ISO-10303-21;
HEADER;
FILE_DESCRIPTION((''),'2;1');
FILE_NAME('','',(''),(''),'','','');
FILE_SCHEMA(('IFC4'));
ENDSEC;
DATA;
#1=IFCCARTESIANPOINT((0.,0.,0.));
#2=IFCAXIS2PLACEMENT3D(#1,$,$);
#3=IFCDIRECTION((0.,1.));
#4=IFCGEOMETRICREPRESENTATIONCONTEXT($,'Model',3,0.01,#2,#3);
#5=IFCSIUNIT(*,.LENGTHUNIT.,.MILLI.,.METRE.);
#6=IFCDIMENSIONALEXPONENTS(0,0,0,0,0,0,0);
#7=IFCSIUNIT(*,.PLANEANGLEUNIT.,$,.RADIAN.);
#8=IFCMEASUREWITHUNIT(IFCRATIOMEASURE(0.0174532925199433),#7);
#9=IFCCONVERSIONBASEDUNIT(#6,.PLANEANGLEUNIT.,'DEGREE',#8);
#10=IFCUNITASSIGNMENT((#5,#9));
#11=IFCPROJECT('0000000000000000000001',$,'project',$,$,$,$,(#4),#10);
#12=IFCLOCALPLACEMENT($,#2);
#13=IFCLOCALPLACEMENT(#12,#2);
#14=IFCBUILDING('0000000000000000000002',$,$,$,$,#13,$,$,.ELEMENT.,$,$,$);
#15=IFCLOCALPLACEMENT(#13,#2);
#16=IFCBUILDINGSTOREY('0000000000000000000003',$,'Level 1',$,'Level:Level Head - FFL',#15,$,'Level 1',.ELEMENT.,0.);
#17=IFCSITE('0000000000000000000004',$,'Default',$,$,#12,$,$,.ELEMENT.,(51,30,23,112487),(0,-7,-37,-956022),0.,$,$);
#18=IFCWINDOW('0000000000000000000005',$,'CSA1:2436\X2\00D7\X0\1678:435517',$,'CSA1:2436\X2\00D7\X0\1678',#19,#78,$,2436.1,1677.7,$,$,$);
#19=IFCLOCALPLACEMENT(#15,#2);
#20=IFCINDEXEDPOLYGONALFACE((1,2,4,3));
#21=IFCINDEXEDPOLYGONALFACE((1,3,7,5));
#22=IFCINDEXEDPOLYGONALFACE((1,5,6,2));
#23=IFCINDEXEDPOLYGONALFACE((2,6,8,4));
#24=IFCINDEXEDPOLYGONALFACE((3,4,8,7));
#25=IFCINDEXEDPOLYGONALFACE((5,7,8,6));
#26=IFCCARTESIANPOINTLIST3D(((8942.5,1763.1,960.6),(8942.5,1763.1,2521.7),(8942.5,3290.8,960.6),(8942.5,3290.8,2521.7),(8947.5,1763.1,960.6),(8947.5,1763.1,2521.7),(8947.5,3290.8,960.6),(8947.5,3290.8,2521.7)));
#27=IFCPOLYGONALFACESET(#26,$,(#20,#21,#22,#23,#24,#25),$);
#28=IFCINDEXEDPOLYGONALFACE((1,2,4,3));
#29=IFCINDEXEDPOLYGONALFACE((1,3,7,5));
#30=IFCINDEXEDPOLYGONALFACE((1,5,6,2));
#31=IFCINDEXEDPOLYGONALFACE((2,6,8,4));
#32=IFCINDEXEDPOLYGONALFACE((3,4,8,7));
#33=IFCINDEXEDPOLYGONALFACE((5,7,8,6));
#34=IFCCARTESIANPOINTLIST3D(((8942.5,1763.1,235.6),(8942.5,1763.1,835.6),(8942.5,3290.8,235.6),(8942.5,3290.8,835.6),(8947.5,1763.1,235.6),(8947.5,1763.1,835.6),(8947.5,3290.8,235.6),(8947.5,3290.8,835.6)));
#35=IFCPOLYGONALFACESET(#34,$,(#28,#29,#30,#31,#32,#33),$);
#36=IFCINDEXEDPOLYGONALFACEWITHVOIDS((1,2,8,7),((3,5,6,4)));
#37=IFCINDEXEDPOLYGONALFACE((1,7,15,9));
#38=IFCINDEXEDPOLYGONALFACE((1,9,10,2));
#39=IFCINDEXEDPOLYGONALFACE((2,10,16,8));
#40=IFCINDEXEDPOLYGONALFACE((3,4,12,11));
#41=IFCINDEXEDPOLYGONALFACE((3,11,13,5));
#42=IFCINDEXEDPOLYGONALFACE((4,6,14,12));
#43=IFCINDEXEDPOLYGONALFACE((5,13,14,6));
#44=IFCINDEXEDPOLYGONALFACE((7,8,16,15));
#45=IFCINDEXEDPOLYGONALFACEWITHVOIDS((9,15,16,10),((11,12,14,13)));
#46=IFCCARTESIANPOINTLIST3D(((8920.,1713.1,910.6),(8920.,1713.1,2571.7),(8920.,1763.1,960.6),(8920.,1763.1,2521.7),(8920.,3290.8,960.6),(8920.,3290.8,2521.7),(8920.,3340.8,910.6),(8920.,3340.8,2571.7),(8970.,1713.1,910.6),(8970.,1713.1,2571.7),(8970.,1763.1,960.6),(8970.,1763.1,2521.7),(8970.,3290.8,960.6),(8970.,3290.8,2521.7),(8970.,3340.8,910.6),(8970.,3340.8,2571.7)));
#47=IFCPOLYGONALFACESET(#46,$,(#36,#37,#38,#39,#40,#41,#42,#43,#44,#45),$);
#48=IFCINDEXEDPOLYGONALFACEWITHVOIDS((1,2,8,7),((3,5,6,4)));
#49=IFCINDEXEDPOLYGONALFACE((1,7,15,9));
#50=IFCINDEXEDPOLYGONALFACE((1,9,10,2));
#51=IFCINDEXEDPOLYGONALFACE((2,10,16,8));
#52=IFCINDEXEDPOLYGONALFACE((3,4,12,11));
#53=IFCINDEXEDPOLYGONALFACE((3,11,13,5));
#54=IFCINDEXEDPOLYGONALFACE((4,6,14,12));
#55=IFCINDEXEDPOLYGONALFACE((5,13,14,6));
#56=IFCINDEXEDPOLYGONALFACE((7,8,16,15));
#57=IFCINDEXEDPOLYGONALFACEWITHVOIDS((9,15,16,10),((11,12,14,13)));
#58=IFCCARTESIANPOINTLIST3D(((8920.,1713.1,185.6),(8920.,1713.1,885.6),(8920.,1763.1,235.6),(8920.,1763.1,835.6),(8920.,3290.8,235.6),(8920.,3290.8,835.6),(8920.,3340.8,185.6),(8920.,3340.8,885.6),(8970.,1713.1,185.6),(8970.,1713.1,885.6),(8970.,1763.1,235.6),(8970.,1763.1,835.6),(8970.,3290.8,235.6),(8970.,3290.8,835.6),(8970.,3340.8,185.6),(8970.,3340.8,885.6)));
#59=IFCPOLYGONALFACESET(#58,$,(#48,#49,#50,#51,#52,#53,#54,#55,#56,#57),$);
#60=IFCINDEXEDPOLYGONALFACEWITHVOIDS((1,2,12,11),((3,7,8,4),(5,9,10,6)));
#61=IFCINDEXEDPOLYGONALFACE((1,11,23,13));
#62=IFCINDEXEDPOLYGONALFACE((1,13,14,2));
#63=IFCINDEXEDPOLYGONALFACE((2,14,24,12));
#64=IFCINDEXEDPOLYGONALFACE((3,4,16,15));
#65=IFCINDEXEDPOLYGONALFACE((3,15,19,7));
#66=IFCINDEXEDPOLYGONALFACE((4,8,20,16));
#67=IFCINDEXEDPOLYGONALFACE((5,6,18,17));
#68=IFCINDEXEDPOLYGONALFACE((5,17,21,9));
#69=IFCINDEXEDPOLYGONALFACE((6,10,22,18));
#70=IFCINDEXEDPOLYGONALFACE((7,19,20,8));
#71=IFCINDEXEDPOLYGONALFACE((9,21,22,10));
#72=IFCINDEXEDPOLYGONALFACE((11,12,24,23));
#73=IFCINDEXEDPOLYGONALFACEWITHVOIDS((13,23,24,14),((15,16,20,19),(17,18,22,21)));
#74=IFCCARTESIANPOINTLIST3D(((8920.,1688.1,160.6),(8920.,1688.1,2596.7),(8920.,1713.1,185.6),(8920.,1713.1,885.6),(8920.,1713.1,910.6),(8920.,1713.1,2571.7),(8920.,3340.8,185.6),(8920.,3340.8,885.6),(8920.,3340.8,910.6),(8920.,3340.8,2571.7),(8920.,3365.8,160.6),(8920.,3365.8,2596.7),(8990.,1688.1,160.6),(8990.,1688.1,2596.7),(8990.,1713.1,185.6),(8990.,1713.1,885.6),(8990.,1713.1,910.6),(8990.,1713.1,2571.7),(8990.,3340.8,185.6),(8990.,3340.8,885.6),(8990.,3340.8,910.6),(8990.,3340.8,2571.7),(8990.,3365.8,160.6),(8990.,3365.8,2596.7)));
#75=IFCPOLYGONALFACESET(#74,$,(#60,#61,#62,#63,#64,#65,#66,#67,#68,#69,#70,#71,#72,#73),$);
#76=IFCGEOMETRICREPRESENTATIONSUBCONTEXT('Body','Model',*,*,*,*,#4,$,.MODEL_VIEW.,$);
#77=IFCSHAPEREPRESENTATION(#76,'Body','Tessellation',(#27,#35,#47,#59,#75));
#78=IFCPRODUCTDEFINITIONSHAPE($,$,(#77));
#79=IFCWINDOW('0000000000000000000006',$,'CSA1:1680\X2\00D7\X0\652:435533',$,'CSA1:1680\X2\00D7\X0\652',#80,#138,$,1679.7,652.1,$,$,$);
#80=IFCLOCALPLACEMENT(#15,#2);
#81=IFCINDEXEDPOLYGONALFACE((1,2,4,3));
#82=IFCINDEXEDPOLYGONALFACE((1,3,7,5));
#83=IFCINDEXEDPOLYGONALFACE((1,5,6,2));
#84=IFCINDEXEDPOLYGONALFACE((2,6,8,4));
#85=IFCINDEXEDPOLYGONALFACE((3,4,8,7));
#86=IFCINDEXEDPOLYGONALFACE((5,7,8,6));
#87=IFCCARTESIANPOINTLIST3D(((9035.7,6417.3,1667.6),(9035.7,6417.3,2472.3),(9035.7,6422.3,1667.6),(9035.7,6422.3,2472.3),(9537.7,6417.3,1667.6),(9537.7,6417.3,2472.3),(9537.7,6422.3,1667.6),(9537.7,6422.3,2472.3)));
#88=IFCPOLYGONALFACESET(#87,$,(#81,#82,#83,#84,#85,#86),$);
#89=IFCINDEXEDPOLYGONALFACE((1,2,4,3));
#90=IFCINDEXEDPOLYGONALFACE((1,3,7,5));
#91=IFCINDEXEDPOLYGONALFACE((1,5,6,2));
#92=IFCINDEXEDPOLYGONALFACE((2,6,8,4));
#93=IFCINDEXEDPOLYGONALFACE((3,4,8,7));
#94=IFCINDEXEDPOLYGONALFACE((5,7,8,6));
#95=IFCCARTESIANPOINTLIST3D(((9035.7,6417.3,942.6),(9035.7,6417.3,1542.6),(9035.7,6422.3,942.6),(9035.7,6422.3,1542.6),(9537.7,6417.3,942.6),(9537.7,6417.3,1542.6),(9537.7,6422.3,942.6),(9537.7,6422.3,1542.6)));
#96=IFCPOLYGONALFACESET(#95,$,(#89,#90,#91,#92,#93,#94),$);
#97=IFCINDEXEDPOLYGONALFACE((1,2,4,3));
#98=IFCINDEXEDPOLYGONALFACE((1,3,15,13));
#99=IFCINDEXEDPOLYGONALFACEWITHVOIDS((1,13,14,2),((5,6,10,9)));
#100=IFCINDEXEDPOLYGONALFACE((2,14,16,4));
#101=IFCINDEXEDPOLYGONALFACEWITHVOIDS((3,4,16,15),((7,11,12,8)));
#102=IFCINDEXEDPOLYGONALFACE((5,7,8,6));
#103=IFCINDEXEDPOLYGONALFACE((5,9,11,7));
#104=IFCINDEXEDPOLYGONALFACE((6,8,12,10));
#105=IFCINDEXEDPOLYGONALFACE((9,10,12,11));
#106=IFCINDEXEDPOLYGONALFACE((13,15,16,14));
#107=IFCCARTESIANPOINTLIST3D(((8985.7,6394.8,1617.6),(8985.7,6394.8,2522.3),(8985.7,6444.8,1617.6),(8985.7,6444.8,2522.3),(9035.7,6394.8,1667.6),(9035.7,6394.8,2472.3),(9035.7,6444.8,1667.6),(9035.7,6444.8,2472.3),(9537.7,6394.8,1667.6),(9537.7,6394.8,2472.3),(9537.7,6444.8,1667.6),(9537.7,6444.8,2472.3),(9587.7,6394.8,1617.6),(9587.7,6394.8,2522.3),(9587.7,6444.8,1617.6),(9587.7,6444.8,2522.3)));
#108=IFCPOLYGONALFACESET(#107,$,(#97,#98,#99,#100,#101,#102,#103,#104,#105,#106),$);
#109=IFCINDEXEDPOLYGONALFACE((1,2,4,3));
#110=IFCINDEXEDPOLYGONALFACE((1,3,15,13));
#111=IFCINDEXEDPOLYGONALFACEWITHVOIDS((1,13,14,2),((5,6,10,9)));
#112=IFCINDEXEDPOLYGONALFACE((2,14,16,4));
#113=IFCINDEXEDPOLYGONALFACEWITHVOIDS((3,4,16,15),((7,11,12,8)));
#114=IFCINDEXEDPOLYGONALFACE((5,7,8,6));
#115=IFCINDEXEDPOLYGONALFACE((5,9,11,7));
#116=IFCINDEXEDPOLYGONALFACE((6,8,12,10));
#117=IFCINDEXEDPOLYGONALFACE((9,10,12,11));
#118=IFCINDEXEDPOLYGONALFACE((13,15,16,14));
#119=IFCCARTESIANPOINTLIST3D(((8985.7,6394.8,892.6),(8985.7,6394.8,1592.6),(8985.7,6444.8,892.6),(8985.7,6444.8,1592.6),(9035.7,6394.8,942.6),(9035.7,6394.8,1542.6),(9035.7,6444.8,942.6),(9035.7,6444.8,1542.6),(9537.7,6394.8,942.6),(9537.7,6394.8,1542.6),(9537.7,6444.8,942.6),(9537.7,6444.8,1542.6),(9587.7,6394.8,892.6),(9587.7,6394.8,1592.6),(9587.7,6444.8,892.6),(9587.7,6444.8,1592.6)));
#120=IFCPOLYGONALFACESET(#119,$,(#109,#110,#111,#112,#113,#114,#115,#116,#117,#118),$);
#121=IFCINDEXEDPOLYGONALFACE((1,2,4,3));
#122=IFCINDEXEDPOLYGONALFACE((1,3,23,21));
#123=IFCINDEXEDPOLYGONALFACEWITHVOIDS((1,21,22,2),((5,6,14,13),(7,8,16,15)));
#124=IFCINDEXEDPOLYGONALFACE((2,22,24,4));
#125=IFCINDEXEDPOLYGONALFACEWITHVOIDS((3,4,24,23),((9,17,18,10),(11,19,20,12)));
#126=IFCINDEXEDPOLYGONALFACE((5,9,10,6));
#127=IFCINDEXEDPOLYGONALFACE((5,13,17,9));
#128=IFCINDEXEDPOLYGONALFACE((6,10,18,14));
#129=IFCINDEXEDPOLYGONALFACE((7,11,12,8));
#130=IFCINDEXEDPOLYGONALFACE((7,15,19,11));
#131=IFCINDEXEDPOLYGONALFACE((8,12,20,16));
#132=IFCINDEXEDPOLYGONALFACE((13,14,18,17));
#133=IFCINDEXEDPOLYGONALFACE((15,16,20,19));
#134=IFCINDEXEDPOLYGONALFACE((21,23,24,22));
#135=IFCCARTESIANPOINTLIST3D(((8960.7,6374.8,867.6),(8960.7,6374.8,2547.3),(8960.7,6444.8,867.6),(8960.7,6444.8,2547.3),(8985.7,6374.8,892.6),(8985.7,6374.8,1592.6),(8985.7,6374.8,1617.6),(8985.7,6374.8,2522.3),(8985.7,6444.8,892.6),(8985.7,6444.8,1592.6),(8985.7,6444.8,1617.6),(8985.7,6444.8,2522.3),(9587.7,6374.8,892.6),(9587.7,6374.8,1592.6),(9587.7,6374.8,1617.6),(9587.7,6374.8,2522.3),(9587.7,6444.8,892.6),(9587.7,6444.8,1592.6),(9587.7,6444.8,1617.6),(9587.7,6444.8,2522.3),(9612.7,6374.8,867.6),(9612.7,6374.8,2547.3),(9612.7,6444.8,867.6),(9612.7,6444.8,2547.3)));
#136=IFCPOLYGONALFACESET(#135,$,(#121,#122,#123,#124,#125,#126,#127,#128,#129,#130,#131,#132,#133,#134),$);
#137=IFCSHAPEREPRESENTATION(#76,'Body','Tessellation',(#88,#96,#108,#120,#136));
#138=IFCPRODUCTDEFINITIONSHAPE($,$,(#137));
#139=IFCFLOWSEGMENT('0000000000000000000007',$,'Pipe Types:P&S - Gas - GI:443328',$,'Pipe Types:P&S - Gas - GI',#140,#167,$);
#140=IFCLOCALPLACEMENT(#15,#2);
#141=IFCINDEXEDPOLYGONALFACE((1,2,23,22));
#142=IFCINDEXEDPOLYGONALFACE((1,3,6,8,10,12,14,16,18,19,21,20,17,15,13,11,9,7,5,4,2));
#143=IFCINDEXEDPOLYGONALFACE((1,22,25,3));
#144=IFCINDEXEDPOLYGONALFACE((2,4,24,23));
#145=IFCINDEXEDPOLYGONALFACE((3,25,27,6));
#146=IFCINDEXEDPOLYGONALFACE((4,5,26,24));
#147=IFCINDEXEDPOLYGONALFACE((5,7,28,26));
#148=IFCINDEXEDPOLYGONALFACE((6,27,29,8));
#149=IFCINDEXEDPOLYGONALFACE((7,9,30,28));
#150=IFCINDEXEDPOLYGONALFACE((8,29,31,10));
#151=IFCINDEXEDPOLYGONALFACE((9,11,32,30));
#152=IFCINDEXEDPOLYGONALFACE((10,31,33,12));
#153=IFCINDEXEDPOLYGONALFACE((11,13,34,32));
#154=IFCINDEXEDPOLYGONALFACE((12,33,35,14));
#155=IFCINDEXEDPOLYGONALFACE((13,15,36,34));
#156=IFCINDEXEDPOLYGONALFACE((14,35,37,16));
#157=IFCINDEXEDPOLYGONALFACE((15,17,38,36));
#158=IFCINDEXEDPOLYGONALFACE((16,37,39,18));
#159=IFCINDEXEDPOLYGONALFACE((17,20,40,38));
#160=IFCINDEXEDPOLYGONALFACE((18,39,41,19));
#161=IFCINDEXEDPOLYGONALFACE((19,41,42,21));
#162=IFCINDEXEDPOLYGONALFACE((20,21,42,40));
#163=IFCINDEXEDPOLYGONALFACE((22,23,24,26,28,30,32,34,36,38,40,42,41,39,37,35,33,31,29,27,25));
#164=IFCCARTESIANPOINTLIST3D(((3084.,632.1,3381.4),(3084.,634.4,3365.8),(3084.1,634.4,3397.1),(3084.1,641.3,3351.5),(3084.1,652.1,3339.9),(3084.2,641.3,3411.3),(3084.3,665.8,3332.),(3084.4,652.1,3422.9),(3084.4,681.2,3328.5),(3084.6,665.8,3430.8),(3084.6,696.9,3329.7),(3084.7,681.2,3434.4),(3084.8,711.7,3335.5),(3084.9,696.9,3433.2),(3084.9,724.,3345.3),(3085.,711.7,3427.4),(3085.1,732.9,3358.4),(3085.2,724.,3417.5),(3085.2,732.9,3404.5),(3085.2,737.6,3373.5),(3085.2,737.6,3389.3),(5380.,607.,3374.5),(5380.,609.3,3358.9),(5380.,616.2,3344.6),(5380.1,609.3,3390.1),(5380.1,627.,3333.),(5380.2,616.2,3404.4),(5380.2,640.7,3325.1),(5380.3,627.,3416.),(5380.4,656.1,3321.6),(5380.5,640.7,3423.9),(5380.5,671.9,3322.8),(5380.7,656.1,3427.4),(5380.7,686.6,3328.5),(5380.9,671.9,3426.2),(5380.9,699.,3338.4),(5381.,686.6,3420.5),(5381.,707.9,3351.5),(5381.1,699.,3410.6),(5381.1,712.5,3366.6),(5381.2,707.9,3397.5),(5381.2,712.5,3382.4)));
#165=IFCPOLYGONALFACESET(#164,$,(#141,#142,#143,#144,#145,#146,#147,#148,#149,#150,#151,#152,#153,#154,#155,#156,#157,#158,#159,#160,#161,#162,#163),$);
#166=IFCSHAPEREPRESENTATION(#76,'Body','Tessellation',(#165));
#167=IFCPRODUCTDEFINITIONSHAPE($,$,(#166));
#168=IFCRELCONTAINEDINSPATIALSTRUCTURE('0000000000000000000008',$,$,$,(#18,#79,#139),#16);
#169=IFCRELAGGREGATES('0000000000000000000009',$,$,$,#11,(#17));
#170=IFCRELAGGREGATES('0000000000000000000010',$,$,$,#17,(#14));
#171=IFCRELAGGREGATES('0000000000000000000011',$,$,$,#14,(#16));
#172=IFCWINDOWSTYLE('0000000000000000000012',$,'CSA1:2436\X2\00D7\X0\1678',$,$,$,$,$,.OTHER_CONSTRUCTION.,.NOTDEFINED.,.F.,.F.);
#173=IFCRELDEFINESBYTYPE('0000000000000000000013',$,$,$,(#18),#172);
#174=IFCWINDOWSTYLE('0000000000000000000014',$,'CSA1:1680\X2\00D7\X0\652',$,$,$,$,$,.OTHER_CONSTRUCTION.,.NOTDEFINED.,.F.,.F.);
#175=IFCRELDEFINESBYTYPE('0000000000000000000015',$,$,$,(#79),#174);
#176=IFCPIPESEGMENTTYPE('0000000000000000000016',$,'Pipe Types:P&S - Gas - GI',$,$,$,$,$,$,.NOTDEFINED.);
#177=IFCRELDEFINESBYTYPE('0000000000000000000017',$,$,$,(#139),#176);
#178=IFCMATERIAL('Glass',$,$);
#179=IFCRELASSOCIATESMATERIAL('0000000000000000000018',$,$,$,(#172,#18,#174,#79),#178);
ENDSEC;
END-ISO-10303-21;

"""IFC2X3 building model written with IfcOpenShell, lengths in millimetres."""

from ifc_helpers import new_model, entity, si_unit, converted_unit, direction, frame, frame_2d, origin, place, context, subcontext, project, spatial, polyline, rectangle, circle, outline, extrude, source, transform, mapped, material, type_object, type_shapes, element, save


model = new_model("IFC2X3")

# Units and contexts
model_context = context("Model", 3, precision=0.01, world=origin(), true_north=direction((0.0, 1.0)))
body_context = subcontext(model_context, "Body", "Model", "MODEL_VIEW")
ifc_project = project(units=[si_unit("LENGTHUNIT", "METRE", prefix="MILLI"), converted_unit("PLANEANGLEUNIT", "DEGREE", entity("IfcRatioMeasure", 0.0174532925199433), si_unit("PLANEANGLEUNIT", "RADIAN"), dimensions=[0, 0, 0, 0, 0, 0, 0])], contexts=[model_context])

# Site, building, storey
site_placement = place(None, origin())
site = spatial("IfcSite", under=ifc_project, at=site_placement, Name="Default", CompositionType="ELEMENT", RefLatitude=(51, 30, 23, 112487), RefLongitude=(0, -7, -37, -956022), RefElevation=0.0)
building_placement = place(site_placement, origin())
building = spatial("IfcBuilding", under=site, at=building_placement, CompositionType="ELEMENT")
storey_placement = place(building_placement, origin())
storey = spatial("IfcBuildingStorey", under=building, at=storey_placement, Name="Level 1", ObjectType="Level:Level Head - FFL", LongName="Level 1", CompositionType="ELEMENT", Elevation=0.0)

# Windows
ifc_material_1 = material(Name="Glass")
window_style_1 = type_object("IfcWindowStyle", Name="CSA1:2436×1678", ConstructionType="OTHER_CONSTRUCTION", OperationType="NOTDEFINED", ParameterTakesPrecedence=False, Sizeable=False, material=ifc_material_1)
shared_shape_1 = source(origin(), body_context, "Body", "SweptSolid", [
    extrude(rectangle(XDim=5.0, YDim=1527.7, at=frame_2d((0.0, 0.0), x_axis=(1.0, 0.0))), frame((838.8, 45.0, 800.0), z_axis=(0.0, 0.0, 1.0), x_axis=(0.0, 1.0, 0.0)), (0.0, 0.0, 1.0), 1561.1),
    extrude(rectangle(XDim=5.0, YDim=1527.7, at=frame_2d((0.0, 0.0), x_axis=(1.0, 0.0))), frame((838.8, 45.0, 75.0), z_axis=(0.0, 0.0, 1.0), x_axis=(0.0, 1.0, 0.0)), (0.0, 0.0, 1.0), 600.0),
    extrude(outline(polyline([(-813.8, -830.6), (813.8, -830.6), (813.8, 830.6), (-813.8, 830.6), (-813.8, -830.6)]), holes=[polyline([(-763.8, -780.6), (-763.8, 780.6), (763.8, 780.6), (763.8, -780.6), (-763.8, -780.6)])]), frame((838.8, 20.0, 1580.6), z_axis=(0.0, 1.0, 0.0), x_axis=(1.0, 0.0, 0.0)), (0.0, 0.0, 1.0), 50.0),
    extrude(outline(polyline([(-813.8, -350.0), (813.8, -350.0), (813.8, 350.0), (-813.8, 350.0), (-813.8, -350.0)]), holes=[polyline([(-763.8, -300.0), (-763.8, 300.0), (763.8, 300.0), (763.8, -300.0), (-763.8, -300.0)])]), frame((838.8, 20.0, 375.0), z_axis=(0.0, 1.0, 0.0), x_axis=(1.0, 0.0, 0.0)), (0.0, 0.0, 1.0), 50.0),
    extrude(outline(polyline([(-838.8, -1218.1), (838.8, -1218.1), (838.8, 1218.1), (-838.8, 1218.1), (-838.8, -1218.1)]), holes=[polyline([(-813.8, -1193.1), (-813.8, 468.1), (813.8, 468.1), (813.8, -1193.1), (-813.8, -1193.1)]), polyline([(-813.8, 493.1), (-813.8, 1193.1), (813.8, 1193.1), (813.8, 493.1), (-813.8, 493.1)])]), frame((838.8, 0.0, 1218.1), z_axis=(0.0, 1.0, 0.0), x_axis=(1.0, 0.0, 0.0)), (0.0, 0.0, 1.0), 70.0),
])
type_shapes(window_style_1, [shared_shape_1])
window_1_placement = place(storey_placement, frame((8990.0, 1688.1, 160.6), z_axis=(0.0, 0.0, 1.0), x_axis=(0.0, 1.0, 0.0)))
element("IfcWindow", 1, at=window_1_placement, inside=storey, type_object=window_style_1, material=ifc_material_1, Name="CSA1:2436×1678:435517", ObjectType="CSA1:2436×1678", OverallHeight=2436.1, OverallWidth=1677.7, context=body_context, shape_type="MappedRepresentation", body=[
    mapped(shared_shape_1, transform((0.0, 0.0, 0.0), scale=1.0)),
])
window_style_2 = type_object("IfcWindowStyle", Name="CSA1:1680×652", ConstructionType="OTHER_CONSTRUCTION", OperationType="NOTDEFINED", ParameterTakesPrecedence=False, Sizeable=False, material=ifc_material_1)
shared_shape_2 = source(origin(), body_context, "Body", "SweptSolid", [
    extrude(rectangle(XDim=5.0, YDim=502.1, at=frame_2d((0.0, 0.0), x_axis=(1.0, 0.0))), frame((326.0, 45.0, 800.0), z_axis=(0.0, 0.0, 1.0), x_axis=(0.0, 1.0, 0.0)), (0.0, 0.0, 1.0), 804.7),
    extrude(rectangle(XDim=5.0, YDim=502.1, at=frame_2d((0.0, 0.0), x_axis=(1.0, 0.0))), frame((326.0, 45.0, 75.0), z_axis=(0.0, 0.0, 1.0), x_axis=(0.0, 1.0, 0.0)), (0.0, 0.0, 1.0), 600.0),
    extrude(outline(polyline([(-301.0, -452.3), (301.0, -452.3), (301.0, 452.3), (-301.0, 452.3), (-301.0, -452.3)]), holes=[polyline([(-251.0, -402.3), (-251.0, 402.3), (251.0, 402.3), (251.0, -402.3), (-251.0, -402.3)])]), frame((326.0, 20.0, 1202.3), z_axis=(0.0, 1.0, 0.0), x_axis=(1.0, 0.0, 0.0)), (0.0, 0.0, 1.0), 50.0),
    extrude(outline(polyline([(-301.0, -350.0), (301.0, -350.0), (301.0, 350.0), (-301.0, 350.0), (-301.0, -350.0)]), holes=[polyline([(-251.0, -300.0), (-251.0, 300.0), (251.0, 300.0), (251.0, -300.0), (-251.0, -300.0)])]), frame((326.0, 20.0, 375.0), z_axis=(0.0, 1.0, 0.0), x_axis=(1.0, 0.0, 0.0)), (0.0, 0.0, 1.0), 50.0),
    extrude(outline(polyline([(-326.0, -839.8), (326.0, -839.8), (326.0, 839.8), (-326.0, 839.8), (-326.0, -839.8)]), holes=[polyline([(-301.0, -814.8), (-301.0, 89.8), (301.0, 89.8), (301.0, -814.8), (-301.0, -814.8)]), polyline([(-301.0, 114.8), (-301.0, 814.8), (301.0, 814.8), (301.0, 114.8), (-301.0, 114.8)])]), frame((326.0, 0.0, 839.8), z_axis=(0.0, 1.0, 0.0), x_axis=(1.0, 0.0, 0.0)), (0.0, 0.0, 1.0), 70.0),
])
type_shapes(window_style_2, [shared_shape_2])
window_2_placement = place(storey_placement, frame((8960.7, 6374.8, 867.6)))
element("IfcWindow", 2, at=window_2_placement, inside=storey, type_object=window_style_2, material=ifc_material_1, Name="CSA1:1680×652:435533", ObjectType="CSA1:1680×652", OverallHeight=1679.7, OverallWidth=652.1, context=body_context, shape_type="MappedRepresentation", body=[
    mapped(shared_shape_2, transform((0.0, 0.0, 0.0), scale=1.0)),
])

# Flow segment
pipe_segment_type = type_object("IfcPipeSegmentType", Name="Pipe Types:P&S - Gas - GI", PredefinedType="NOTDEFINED")
flow_segment_1_placement = place(storey_placement, origin())
element("IfcFlowSegment", 3, at=flow_segment_1_placement, inside=storey, type_object=pipe_segment_type, Name="Pipe Types:P&S - Gas - GI:443328", ObjectType="Pipe Types:P&S - Gas - GI", context=body_context, shape_type="SweptSolid", body=[
    extrude(circle(Radius=53.1, at=frame_2d((0.0, 0.0), x_axis=(1.0, 0.0))), frame((5380.6, 660.1, 3374.5), z_axis=(-0.999936, 0.010924, 0.003021), x_axis=(-0.010924, -0.99994, 0.0)), (0.0, 0.0, 1.0), 2296.1),
])

save(model, "model.ifc")
